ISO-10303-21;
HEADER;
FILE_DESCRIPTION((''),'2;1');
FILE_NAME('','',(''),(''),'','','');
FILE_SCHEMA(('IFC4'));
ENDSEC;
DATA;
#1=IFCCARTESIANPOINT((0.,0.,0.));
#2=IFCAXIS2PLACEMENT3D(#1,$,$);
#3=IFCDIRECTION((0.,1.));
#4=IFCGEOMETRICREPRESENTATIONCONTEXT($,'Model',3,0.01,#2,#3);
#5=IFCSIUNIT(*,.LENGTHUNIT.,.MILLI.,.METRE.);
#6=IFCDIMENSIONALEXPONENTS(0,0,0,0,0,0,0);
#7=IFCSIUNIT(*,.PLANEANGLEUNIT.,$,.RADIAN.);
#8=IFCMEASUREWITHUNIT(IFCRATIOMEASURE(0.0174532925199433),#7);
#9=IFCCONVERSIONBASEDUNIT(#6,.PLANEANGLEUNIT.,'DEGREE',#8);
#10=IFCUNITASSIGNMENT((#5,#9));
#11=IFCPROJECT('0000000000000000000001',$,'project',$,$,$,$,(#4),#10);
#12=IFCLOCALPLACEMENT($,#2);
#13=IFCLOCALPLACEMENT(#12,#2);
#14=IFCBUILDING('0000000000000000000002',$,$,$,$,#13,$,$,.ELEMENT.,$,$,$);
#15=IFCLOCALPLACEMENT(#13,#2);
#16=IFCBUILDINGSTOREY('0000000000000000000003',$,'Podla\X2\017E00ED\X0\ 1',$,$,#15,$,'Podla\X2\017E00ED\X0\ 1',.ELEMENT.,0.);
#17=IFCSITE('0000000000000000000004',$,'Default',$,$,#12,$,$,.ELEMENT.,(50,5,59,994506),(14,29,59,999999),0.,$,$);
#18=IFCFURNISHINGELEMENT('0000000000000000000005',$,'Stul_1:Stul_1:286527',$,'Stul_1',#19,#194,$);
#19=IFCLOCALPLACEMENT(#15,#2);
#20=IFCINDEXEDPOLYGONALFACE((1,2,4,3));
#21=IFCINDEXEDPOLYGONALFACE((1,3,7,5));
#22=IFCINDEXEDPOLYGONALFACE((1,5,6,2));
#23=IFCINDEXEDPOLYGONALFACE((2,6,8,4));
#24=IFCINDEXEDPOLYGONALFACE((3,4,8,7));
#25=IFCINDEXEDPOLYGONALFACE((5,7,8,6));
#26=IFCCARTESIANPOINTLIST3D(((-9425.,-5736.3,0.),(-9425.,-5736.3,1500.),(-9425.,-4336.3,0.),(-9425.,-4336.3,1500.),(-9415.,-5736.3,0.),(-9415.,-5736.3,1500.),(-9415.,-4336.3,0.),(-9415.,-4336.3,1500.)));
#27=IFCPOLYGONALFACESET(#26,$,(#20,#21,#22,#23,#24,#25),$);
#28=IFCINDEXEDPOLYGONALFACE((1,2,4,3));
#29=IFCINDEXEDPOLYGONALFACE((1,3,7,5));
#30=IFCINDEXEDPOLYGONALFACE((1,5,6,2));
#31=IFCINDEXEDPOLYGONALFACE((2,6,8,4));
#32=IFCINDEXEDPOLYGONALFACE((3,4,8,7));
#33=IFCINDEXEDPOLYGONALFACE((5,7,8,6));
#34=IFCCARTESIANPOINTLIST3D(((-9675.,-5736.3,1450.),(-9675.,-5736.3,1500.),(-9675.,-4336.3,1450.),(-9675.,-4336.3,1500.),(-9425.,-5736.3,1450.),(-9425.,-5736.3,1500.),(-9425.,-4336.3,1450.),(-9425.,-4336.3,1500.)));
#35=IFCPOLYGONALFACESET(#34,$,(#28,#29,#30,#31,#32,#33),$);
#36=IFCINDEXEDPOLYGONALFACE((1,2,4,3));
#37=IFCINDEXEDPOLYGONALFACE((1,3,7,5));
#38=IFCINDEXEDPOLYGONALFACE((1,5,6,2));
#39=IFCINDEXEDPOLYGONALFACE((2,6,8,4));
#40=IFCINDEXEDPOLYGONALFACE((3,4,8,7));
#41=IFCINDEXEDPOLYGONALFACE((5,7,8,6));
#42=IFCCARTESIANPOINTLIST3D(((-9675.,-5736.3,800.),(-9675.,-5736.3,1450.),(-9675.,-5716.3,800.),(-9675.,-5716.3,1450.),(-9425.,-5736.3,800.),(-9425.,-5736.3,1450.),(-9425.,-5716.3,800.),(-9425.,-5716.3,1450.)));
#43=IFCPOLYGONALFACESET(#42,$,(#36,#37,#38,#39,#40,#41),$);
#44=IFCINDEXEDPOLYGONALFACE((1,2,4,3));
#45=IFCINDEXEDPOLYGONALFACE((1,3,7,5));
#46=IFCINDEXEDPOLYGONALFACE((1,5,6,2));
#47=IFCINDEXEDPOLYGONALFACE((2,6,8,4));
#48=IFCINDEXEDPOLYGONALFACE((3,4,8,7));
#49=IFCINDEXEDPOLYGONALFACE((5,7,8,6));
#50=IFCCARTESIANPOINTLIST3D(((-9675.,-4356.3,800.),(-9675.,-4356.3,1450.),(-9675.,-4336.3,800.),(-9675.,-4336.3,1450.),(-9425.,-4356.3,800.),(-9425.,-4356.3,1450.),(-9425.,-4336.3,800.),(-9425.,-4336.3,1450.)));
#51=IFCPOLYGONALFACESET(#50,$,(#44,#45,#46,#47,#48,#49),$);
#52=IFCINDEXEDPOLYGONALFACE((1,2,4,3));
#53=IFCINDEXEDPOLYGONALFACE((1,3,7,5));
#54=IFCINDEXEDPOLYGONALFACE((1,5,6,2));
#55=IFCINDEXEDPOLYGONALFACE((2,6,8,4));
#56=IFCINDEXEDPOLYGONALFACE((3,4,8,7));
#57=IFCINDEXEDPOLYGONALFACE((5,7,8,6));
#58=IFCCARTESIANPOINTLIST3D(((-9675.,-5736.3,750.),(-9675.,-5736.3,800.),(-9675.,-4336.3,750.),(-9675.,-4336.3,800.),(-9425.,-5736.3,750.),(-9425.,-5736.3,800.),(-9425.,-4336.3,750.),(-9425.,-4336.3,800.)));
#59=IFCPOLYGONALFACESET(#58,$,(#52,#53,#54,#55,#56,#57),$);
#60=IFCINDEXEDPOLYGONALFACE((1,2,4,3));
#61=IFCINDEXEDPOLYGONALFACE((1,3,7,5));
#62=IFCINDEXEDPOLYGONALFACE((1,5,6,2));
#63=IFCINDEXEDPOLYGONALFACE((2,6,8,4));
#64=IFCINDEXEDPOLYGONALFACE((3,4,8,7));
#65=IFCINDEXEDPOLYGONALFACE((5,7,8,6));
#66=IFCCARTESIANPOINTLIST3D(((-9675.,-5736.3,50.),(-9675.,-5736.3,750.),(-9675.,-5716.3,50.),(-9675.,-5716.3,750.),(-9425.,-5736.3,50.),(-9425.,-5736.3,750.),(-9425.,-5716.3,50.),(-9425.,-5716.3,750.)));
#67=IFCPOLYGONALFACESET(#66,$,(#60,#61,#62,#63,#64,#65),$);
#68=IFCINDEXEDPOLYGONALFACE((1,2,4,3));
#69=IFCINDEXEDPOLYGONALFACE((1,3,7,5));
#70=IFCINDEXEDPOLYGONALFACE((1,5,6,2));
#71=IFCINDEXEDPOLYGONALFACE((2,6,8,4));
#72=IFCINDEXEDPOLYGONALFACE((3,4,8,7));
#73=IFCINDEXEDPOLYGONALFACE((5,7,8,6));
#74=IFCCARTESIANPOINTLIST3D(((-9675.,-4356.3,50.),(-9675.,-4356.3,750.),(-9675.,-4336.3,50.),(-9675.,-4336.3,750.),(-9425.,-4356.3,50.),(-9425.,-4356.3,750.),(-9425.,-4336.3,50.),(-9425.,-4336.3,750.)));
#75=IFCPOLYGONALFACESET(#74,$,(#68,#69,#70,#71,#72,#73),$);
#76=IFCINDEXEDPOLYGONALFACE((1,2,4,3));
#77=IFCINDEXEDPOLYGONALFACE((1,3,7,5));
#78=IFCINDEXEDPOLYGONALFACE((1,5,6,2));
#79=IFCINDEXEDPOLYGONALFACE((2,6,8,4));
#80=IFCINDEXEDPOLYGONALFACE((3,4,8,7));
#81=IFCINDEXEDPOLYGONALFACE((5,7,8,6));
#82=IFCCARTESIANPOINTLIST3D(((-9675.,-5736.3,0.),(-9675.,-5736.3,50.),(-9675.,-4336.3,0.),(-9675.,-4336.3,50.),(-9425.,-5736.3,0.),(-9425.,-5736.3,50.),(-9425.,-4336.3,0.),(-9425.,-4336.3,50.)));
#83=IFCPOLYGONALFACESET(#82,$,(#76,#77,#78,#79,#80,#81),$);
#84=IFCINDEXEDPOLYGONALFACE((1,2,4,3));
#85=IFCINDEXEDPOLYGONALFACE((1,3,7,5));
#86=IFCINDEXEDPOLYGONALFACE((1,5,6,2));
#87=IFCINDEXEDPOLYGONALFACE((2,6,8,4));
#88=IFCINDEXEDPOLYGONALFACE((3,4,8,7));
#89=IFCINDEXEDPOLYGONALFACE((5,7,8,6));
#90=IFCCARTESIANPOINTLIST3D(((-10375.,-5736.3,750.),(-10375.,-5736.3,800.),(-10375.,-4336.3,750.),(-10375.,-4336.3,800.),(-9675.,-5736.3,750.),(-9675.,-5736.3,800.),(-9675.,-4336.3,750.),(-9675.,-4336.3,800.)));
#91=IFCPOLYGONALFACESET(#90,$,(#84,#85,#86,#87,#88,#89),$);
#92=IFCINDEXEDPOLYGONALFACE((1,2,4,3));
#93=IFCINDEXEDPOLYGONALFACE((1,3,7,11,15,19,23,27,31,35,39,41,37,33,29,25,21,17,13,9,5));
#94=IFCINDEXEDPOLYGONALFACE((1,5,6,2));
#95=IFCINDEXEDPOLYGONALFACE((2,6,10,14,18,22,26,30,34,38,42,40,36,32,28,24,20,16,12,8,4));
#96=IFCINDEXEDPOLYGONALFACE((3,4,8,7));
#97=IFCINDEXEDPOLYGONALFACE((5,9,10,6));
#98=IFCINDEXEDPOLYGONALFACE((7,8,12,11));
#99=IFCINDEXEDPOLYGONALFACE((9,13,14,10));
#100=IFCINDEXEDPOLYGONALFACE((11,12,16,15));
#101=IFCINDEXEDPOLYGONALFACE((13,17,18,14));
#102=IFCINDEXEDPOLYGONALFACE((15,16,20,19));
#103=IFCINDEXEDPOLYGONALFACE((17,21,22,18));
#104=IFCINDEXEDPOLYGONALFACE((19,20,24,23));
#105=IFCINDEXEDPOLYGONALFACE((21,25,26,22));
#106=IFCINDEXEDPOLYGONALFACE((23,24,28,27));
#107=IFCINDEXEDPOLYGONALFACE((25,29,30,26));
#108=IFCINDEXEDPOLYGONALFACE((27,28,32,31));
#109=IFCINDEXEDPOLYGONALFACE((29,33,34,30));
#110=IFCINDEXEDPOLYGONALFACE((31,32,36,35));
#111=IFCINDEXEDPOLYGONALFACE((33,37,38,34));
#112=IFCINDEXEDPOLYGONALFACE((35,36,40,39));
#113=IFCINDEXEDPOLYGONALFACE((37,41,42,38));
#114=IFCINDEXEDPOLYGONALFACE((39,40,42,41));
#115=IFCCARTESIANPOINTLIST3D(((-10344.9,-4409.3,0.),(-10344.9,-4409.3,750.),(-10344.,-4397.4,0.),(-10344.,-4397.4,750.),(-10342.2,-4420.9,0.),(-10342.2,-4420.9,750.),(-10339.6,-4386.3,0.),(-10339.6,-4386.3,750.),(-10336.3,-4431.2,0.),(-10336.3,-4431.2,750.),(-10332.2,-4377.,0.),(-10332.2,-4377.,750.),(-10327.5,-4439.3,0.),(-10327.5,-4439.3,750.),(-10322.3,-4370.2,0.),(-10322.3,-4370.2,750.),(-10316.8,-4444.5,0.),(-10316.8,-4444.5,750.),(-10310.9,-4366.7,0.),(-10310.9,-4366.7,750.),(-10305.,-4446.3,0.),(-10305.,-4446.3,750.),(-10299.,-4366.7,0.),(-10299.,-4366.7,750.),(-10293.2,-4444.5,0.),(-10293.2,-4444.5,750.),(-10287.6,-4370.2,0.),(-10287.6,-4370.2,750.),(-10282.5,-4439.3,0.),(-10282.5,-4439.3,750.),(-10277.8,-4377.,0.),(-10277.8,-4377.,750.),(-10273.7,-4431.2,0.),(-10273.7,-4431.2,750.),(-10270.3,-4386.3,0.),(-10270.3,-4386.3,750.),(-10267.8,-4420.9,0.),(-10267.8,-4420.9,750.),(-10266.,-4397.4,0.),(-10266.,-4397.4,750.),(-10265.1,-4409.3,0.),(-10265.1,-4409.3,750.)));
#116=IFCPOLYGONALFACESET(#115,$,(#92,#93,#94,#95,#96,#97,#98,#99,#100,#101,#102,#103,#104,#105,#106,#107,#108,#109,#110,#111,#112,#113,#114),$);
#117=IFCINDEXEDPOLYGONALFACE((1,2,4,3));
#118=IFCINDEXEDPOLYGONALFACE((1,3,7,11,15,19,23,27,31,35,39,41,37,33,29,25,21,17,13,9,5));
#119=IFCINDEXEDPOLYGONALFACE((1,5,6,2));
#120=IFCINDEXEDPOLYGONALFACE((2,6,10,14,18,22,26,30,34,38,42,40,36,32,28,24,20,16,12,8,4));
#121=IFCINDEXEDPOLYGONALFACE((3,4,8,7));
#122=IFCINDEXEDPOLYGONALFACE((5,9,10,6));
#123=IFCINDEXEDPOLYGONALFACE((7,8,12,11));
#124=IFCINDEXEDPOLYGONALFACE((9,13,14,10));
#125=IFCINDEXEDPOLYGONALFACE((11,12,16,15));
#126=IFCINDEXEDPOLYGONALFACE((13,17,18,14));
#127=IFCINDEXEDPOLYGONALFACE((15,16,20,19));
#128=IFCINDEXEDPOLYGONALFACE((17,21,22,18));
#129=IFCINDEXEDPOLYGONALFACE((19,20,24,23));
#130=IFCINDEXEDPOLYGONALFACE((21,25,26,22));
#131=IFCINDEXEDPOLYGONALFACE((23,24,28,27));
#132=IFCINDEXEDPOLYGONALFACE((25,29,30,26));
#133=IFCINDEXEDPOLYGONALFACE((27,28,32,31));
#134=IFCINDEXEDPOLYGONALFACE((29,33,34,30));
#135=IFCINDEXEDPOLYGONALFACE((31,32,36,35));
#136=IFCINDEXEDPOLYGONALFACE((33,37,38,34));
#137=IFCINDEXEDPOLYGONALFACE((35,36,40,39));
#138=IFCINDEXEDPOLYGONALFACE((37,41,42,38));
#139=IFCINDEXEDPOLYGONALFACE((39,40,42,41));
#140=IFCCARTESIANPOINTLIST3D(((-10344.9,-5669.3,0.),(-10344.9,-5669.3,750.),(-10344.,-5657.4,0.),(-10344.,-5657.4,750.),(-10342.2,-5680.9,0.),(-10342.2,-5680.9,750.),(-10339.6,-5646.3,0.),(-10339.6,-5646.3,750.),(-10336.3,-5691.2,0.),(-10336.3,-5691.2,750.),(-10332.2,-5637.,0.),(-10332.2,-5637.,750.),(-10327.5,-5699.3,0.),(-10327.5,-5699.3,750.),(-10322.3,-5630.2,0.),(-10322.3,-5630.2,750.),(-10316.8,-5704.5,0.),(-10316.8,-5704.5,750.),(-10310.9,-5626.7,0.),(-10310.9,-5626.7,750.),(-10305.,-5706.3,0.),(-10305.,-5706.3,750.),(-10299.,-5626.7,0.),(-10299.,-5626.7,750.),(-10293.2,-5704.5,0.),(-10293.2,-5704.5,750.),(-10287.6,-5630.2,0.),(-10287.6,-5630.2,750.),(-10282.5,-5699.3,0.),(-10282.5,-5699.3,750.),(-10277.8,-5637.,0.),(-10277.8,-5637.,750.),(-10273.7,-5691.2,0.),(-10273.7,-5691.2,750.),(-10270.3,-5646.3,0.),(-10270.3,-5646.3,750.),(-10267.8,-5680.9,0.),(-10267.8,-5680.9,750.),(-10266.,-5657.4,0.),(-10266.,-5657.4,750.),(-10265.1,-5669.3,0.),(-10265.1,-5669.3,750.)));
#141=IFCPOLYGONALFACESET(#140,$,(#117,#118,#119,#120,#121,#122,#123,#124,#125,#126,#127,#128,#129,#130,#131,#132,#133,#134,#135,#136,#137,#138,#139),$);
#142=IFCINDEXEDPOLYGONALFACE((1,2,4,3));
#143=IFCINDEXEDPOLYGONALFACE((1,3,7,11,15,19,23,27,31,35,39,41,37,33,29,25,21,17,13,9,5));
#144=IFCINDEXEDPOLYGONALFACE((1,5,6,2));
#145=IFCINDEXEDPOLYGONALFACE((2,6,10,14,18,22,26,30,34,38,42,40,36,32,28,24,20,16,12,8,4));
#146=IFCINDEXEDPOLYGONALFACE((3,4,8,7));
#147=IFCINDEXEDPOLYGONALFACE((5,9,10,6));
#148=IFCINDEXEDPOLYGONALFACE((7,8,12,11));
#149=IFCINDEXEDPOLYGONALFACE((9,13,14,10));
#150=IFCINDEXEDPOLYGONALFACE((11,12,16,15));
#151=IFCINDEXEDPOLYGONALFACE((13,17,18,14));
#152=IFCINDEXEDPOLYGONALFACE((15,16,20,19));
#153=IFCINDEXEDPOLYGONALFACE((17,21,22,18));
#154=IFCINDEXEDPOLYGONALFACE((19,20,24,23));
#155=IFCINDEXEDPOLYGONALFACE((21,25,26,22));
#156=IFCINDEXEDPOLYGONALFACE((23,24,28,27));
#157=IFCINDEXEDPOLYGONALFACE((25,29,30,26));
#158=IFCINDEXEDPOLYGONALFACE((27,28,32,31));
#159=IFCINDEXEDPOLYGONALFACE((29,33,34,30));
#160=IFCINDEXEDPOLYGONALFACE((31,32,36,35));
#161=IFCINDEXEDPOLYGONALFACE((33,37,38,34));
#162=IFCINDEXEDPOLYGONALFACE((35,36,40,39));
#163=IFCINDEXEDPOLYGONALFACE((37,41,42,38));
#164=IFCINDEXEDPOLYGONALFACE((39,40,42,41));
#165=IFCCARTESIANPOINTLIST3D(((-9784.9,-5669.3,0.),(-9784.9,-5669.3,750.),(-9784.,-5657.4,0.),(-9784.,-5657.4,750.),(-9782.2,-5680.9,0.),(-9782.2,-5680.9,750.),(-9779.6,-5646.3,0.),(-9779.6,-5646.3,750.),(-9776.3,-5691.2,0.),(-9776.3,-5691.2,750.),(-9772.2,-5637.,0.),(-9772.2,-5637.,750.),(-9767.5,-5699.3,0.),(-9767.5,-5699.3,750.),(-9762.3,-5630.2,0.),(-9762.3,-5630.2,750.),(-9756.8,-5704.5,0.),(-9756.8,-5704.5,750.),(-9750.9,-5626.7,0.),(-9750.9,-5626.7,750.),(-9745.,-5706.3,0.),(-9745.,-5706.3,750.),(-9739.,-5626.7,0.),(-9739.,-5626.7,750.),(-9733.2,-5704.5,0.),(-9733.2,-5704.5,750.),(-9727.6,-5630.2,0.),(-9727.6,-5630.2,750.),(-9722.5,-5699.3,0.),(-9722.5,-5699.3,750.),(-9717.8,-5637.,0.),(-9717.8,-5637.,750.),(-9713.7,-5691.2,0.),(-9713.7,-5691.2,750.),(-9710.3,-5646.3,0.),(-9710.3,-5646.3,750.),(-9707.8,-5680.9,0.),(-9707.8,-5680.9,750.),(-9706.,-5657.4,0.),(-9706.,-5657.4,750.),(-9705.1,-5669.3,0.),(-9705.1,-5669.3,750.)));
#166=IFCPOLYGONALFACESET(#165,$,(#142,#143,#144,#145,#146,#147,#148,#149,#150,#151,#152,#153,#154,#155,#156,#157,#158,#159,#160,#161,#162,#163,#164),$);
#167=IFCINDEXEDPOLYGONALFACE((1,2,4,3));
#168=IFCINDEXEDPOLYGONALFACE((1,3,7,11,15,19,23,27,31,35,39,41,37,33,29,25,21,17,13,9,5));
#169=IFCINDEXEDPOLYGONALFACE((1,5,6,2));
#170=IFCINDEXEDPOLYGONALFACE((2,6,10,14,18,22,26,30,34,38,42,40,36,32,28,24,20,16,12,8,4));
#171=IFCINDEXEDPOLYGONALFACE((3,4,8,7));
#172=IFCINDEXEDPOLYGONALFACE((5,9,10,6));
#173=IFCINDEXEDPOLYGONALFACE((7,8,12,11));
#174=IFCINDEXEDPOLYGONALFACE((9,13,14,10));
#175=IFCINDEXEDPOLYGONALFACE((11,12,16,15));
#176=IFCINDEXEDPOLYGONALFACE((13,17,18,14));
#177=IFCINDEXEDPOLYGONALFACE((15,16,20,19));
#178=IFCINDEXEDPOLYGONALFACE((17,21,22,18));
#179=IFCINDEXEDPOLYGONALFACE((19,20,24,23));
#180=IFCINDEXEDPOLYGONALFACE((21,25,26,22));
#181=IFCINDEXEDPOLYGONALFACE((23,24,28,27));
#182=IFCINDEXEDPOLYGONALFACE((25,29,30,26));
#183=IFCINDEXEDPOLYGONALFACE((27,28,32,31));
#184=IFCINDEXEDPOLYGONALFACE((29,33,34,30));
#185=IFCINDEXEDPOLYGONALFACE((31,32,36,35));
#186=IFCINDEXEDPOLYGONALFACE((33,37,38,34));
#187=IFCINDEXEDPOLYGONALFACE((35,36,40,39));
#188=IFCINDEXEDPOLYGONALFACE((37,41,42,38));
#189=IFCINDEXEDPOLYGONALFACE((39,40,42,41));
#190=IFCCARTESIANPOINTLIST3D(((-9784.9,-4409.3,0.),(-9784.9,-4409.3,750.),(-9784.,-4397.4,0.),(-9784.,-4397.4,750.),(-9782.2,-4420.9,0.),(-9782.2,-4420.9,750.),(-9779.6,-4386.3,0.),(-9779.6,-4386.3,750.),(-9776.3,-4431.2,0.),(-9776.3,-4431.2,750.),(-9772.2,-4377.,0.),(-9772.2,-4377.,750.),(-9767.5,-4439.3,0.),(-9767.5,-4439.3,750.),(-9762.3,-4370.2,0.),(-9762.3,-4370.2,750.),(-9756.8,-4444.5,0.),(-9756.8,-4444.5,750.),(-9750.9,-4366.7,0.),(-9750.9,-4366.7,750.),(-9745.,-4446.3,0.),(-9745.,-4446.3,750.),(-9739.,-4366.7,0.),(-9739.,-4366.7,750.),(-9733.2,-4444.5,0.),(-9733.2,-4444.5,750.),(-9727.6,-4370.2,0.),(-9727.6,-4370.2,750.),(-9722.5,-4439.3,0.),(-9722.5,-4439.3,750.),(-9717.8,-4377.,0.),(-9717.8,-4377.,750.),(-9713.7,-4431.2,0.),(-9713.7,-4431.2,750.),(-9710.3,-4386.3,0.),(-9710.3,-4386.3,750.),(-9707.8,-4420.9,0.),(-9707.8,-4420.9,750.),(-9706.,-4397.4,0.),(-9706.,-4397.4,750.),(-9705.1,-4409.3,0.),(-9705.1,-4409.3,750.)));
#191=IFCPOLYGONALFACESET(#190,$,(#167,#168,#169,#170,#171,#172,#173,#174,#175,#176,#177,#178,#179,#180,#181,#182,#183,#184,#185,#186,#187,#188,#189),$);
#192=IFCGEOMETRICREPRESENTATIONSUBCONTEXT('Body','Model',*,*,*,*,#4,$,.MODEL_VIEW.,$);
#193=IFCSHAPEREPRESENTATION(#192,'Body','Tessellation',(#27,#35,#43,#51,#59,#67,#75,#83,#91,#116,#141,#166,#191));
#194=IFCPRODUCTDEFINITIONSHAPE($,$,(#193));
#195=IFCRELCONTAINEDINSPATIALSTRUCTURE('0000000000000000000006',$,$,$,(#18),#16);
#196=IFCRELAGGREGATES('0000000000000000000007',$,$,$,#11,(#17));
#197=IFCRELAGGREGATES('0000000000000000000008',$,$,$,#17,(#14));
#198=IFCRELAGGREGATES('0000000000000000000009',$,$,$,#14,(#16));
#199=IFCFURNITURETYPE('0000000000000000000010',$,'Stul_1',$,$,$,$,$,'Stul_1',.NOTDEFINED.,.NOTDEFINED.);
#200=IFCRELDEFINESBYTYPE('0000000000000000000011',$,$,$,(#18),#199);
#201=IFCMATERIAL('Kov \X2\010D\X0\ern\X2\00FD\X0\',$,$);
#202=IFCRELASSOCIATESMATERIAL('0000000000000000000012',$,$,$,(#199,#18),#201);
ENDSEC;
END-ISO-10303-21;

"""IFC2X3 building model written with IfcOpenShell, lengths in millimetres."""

from ifc_helpers import new_model, entity, si_unit, converted_unit, direction, frame, frame_2d, origin, origin_2d_with_axis, place, context, subcontext, project, spatial, rectangle, circle, extrude, source, transform, mapped, material, type_object, type_shapes, element, save


model = new_model("IFC2X3")

# Units and contexts
model_context = context("Model", 3, precision=0.01, world=origin(), true_north=direction((0.0, 1.0)))
body_context = subcontext(model_context, "Body", "Model", "MODEL_VIEW")
ifc_project = project(units=[si_unit("LENGTHUNIT", "METRE", prefix="MILLI"), converted_unit("PLANEANGLEUNIT", "DEGREE", entity("IfcRatioMeasure", 0.0174532925199433), si_unit("PLANEANGLEUNIT", "RADIAN"), dimensions=[0, 0, 0, 0, 0, 0, 0])], contexts=[model_context])

# Site, building, storey
site_placement = place(None, origin())
site = spatial("IfcSite", under=ifc_project, at=site_placement, Name="Default", CompositionType="ELEMENT", RefLatitude=(50, 5, 59, 994506), RefLongitude=(14, 29, 59, 999999), RefElevation=0.0)
building_placement = place(site_placement, origin())
building = spatial("IfcBuilding", under=site, at=building_placement, CompositionType="ELEMENT")
storey_placement = place(building_placement, origin())
storey = spatial("IfcBuildingStorey", under=building, at=storey_placement, Name="Podlaží 1", LongName="Podlaží 1", CompositionType="ELEMENT", Elevation=0.0)

# Furnishing element
ifc_material_1 = material(Name="Kov černý")
furniture_type = type_object("IfcFurnitureType", Name="Stul_1", ElementType="Stul_1", material=ifc_material_1)
shared_shape_1 = source(origin(), body_context, "Body", "SweptSolid", [
    extrude(rectangle(XDim=1400.0, YDim=10.0, at=origin_2d_with_axis()), frame((0.0, 605.0, 0.0), z_axis=(0.0, 0.0, 1.0), x_axis=(-1.0, 0.0, 0.0)), (0.0, 0.0, 1.0), 1500.0),
    extrude(rectangle(XDim=1400.0, YDim=250.0, at=frame_2d((0.0, 0.0), x_axis=(1.0, 0.0))), frame((0.0, 475.0, 1450.0), z_axis=(0.0, 0.0, 1.0), x_axis=(-1.0, 0.0, 0.0)), (0.0, 0.0, 1.0), 50.0),
    extrude(rectangle(XDim=20.0, YDim=250.0, at=origin_2d_with_axis()), frame((690.0, 475.0, 800.0), z_axis=(0.0, 0.0, 1.0), x_axis=(-1.0, 0.0, 0.0)), (0.0, 0.0, 1.0), 650.0),
    extrude(rectangle(XDim=20.0, YDim=250.0, at=frame_2d((0.0, 0.0), x_axis=(1.0, 0.0))), frame((-690.0, 475.0, 800.0), z_axis=(0.0, 0.0, 1.0), x_axis=(-1.0, 0.0, 0.0)), (0.0, 0.0, 1.0), 650.0),
    extrude(rectangle(XDim=1400.0, YDim=250.0, at=origin_2d_with_axis()), frame((0.0, 475.0, 750.0), z_axis=(0.0, 0.0, 1.0), x_axis=(-1.0, 0.0, 0.0)), (0.0, 0.0, 1.0), 50.0),
    extrude(rectangle(XDim=20.0, YDim=250.0, at=origin_2d_with_axis()), frame((690.0, 475.0, 50.0), z_axis=(0.0, 0.0, 1.0), x_axis=(-1.0, 0.0, 0.0)), (0.0, 0.0, 1.0), 700.0),
    extrude(rectangle(XDim=20.0, YDim=250.0, at=frame_2d((0.0, 0.0), x_axis=(1.0, 0.0))), frame((-690.0, 475.0, 50.0), z_axis=(0.0, 0.0, 1.0), x_axis=(-1.0, 0.0, 0.0)), (0.0, 0.0, 1.0), 700.0),
    extrude(rectangle(XDim=1400.0, YDim=250.0, at=origin_2d_with_axis()), frame((0.0, 475.0, 0.0), z_axis=(0.0, 0.0, 1.0), x_axis=(-1.0, 0.0, 0.0)), (0.0, 0.0, 1.0), 50.0),
    extrude(rectangle(XDim=1400.0, YDim=700.0, at=origin_2d_with_axis()), frame((0.0, 0.0, 750.0), z_axis=(0.0, 0.0, 1.0), x_axis=(-1.0, 0.0, 0.0)), (0.0, 0.0, 1.0), 50.0),
    extrude(circle(Radius=40.0, at=frame_2d((0.0, 0.0), x_axis=(1.0, 0.0))), frame((-630.0, -280.0, 0.0)), (0.0, 0.0, 1.0), 750.0),
    extrude(circle(Radius=40.0, at=frame_2d((0.0, 0.0), x_axis=(1.0, 0.0))), frame((630.0, -280.0, 0.0)), (0.0, 0.0, 1.0), 750.0),
    extrude(circle(Radius=40.0, at=frame_2d((0.0, 0.0), x_axis=(1.0, 0.0))), frame((630.0, 280.0, 0.0)), (0.0, 0.0, 1.0), 750.0),
    extrude(circle(Radius=40.0, at=frame_2d((0.0, 0.0), x_axis=(1.0, 0.0))), frame((-630.0, 280.0, 0.0)), (0.0, 0.0, 1.0), 750.0),
])
type_shapes(furniture_type, [shared_shape_1])
for number, where, z_axis, x_axis, name in (
    (1, (-10025.0, -5036.3, 0.0), (0.0, 0.0, 1.0), (0.0, -1.0, 0.0), "Stul_1:Stul_1:286527"),
):
    element("IfcFurnishingElement", number, at=place(storey_placement, frame(where, z_axis=z_axis, x_axis=x_axis)), inside=storey, type_object=furniture_type, material=ifc_material_1, Name=name, ObjectType="Stul_1", context=body_context, shape_type="MappedRepresentation", body=[
        mapped(shared_shape_1, transform((0.0, 0.0, 0.0), scale=1.0)),
    ])

save(model, "model.ifc")
